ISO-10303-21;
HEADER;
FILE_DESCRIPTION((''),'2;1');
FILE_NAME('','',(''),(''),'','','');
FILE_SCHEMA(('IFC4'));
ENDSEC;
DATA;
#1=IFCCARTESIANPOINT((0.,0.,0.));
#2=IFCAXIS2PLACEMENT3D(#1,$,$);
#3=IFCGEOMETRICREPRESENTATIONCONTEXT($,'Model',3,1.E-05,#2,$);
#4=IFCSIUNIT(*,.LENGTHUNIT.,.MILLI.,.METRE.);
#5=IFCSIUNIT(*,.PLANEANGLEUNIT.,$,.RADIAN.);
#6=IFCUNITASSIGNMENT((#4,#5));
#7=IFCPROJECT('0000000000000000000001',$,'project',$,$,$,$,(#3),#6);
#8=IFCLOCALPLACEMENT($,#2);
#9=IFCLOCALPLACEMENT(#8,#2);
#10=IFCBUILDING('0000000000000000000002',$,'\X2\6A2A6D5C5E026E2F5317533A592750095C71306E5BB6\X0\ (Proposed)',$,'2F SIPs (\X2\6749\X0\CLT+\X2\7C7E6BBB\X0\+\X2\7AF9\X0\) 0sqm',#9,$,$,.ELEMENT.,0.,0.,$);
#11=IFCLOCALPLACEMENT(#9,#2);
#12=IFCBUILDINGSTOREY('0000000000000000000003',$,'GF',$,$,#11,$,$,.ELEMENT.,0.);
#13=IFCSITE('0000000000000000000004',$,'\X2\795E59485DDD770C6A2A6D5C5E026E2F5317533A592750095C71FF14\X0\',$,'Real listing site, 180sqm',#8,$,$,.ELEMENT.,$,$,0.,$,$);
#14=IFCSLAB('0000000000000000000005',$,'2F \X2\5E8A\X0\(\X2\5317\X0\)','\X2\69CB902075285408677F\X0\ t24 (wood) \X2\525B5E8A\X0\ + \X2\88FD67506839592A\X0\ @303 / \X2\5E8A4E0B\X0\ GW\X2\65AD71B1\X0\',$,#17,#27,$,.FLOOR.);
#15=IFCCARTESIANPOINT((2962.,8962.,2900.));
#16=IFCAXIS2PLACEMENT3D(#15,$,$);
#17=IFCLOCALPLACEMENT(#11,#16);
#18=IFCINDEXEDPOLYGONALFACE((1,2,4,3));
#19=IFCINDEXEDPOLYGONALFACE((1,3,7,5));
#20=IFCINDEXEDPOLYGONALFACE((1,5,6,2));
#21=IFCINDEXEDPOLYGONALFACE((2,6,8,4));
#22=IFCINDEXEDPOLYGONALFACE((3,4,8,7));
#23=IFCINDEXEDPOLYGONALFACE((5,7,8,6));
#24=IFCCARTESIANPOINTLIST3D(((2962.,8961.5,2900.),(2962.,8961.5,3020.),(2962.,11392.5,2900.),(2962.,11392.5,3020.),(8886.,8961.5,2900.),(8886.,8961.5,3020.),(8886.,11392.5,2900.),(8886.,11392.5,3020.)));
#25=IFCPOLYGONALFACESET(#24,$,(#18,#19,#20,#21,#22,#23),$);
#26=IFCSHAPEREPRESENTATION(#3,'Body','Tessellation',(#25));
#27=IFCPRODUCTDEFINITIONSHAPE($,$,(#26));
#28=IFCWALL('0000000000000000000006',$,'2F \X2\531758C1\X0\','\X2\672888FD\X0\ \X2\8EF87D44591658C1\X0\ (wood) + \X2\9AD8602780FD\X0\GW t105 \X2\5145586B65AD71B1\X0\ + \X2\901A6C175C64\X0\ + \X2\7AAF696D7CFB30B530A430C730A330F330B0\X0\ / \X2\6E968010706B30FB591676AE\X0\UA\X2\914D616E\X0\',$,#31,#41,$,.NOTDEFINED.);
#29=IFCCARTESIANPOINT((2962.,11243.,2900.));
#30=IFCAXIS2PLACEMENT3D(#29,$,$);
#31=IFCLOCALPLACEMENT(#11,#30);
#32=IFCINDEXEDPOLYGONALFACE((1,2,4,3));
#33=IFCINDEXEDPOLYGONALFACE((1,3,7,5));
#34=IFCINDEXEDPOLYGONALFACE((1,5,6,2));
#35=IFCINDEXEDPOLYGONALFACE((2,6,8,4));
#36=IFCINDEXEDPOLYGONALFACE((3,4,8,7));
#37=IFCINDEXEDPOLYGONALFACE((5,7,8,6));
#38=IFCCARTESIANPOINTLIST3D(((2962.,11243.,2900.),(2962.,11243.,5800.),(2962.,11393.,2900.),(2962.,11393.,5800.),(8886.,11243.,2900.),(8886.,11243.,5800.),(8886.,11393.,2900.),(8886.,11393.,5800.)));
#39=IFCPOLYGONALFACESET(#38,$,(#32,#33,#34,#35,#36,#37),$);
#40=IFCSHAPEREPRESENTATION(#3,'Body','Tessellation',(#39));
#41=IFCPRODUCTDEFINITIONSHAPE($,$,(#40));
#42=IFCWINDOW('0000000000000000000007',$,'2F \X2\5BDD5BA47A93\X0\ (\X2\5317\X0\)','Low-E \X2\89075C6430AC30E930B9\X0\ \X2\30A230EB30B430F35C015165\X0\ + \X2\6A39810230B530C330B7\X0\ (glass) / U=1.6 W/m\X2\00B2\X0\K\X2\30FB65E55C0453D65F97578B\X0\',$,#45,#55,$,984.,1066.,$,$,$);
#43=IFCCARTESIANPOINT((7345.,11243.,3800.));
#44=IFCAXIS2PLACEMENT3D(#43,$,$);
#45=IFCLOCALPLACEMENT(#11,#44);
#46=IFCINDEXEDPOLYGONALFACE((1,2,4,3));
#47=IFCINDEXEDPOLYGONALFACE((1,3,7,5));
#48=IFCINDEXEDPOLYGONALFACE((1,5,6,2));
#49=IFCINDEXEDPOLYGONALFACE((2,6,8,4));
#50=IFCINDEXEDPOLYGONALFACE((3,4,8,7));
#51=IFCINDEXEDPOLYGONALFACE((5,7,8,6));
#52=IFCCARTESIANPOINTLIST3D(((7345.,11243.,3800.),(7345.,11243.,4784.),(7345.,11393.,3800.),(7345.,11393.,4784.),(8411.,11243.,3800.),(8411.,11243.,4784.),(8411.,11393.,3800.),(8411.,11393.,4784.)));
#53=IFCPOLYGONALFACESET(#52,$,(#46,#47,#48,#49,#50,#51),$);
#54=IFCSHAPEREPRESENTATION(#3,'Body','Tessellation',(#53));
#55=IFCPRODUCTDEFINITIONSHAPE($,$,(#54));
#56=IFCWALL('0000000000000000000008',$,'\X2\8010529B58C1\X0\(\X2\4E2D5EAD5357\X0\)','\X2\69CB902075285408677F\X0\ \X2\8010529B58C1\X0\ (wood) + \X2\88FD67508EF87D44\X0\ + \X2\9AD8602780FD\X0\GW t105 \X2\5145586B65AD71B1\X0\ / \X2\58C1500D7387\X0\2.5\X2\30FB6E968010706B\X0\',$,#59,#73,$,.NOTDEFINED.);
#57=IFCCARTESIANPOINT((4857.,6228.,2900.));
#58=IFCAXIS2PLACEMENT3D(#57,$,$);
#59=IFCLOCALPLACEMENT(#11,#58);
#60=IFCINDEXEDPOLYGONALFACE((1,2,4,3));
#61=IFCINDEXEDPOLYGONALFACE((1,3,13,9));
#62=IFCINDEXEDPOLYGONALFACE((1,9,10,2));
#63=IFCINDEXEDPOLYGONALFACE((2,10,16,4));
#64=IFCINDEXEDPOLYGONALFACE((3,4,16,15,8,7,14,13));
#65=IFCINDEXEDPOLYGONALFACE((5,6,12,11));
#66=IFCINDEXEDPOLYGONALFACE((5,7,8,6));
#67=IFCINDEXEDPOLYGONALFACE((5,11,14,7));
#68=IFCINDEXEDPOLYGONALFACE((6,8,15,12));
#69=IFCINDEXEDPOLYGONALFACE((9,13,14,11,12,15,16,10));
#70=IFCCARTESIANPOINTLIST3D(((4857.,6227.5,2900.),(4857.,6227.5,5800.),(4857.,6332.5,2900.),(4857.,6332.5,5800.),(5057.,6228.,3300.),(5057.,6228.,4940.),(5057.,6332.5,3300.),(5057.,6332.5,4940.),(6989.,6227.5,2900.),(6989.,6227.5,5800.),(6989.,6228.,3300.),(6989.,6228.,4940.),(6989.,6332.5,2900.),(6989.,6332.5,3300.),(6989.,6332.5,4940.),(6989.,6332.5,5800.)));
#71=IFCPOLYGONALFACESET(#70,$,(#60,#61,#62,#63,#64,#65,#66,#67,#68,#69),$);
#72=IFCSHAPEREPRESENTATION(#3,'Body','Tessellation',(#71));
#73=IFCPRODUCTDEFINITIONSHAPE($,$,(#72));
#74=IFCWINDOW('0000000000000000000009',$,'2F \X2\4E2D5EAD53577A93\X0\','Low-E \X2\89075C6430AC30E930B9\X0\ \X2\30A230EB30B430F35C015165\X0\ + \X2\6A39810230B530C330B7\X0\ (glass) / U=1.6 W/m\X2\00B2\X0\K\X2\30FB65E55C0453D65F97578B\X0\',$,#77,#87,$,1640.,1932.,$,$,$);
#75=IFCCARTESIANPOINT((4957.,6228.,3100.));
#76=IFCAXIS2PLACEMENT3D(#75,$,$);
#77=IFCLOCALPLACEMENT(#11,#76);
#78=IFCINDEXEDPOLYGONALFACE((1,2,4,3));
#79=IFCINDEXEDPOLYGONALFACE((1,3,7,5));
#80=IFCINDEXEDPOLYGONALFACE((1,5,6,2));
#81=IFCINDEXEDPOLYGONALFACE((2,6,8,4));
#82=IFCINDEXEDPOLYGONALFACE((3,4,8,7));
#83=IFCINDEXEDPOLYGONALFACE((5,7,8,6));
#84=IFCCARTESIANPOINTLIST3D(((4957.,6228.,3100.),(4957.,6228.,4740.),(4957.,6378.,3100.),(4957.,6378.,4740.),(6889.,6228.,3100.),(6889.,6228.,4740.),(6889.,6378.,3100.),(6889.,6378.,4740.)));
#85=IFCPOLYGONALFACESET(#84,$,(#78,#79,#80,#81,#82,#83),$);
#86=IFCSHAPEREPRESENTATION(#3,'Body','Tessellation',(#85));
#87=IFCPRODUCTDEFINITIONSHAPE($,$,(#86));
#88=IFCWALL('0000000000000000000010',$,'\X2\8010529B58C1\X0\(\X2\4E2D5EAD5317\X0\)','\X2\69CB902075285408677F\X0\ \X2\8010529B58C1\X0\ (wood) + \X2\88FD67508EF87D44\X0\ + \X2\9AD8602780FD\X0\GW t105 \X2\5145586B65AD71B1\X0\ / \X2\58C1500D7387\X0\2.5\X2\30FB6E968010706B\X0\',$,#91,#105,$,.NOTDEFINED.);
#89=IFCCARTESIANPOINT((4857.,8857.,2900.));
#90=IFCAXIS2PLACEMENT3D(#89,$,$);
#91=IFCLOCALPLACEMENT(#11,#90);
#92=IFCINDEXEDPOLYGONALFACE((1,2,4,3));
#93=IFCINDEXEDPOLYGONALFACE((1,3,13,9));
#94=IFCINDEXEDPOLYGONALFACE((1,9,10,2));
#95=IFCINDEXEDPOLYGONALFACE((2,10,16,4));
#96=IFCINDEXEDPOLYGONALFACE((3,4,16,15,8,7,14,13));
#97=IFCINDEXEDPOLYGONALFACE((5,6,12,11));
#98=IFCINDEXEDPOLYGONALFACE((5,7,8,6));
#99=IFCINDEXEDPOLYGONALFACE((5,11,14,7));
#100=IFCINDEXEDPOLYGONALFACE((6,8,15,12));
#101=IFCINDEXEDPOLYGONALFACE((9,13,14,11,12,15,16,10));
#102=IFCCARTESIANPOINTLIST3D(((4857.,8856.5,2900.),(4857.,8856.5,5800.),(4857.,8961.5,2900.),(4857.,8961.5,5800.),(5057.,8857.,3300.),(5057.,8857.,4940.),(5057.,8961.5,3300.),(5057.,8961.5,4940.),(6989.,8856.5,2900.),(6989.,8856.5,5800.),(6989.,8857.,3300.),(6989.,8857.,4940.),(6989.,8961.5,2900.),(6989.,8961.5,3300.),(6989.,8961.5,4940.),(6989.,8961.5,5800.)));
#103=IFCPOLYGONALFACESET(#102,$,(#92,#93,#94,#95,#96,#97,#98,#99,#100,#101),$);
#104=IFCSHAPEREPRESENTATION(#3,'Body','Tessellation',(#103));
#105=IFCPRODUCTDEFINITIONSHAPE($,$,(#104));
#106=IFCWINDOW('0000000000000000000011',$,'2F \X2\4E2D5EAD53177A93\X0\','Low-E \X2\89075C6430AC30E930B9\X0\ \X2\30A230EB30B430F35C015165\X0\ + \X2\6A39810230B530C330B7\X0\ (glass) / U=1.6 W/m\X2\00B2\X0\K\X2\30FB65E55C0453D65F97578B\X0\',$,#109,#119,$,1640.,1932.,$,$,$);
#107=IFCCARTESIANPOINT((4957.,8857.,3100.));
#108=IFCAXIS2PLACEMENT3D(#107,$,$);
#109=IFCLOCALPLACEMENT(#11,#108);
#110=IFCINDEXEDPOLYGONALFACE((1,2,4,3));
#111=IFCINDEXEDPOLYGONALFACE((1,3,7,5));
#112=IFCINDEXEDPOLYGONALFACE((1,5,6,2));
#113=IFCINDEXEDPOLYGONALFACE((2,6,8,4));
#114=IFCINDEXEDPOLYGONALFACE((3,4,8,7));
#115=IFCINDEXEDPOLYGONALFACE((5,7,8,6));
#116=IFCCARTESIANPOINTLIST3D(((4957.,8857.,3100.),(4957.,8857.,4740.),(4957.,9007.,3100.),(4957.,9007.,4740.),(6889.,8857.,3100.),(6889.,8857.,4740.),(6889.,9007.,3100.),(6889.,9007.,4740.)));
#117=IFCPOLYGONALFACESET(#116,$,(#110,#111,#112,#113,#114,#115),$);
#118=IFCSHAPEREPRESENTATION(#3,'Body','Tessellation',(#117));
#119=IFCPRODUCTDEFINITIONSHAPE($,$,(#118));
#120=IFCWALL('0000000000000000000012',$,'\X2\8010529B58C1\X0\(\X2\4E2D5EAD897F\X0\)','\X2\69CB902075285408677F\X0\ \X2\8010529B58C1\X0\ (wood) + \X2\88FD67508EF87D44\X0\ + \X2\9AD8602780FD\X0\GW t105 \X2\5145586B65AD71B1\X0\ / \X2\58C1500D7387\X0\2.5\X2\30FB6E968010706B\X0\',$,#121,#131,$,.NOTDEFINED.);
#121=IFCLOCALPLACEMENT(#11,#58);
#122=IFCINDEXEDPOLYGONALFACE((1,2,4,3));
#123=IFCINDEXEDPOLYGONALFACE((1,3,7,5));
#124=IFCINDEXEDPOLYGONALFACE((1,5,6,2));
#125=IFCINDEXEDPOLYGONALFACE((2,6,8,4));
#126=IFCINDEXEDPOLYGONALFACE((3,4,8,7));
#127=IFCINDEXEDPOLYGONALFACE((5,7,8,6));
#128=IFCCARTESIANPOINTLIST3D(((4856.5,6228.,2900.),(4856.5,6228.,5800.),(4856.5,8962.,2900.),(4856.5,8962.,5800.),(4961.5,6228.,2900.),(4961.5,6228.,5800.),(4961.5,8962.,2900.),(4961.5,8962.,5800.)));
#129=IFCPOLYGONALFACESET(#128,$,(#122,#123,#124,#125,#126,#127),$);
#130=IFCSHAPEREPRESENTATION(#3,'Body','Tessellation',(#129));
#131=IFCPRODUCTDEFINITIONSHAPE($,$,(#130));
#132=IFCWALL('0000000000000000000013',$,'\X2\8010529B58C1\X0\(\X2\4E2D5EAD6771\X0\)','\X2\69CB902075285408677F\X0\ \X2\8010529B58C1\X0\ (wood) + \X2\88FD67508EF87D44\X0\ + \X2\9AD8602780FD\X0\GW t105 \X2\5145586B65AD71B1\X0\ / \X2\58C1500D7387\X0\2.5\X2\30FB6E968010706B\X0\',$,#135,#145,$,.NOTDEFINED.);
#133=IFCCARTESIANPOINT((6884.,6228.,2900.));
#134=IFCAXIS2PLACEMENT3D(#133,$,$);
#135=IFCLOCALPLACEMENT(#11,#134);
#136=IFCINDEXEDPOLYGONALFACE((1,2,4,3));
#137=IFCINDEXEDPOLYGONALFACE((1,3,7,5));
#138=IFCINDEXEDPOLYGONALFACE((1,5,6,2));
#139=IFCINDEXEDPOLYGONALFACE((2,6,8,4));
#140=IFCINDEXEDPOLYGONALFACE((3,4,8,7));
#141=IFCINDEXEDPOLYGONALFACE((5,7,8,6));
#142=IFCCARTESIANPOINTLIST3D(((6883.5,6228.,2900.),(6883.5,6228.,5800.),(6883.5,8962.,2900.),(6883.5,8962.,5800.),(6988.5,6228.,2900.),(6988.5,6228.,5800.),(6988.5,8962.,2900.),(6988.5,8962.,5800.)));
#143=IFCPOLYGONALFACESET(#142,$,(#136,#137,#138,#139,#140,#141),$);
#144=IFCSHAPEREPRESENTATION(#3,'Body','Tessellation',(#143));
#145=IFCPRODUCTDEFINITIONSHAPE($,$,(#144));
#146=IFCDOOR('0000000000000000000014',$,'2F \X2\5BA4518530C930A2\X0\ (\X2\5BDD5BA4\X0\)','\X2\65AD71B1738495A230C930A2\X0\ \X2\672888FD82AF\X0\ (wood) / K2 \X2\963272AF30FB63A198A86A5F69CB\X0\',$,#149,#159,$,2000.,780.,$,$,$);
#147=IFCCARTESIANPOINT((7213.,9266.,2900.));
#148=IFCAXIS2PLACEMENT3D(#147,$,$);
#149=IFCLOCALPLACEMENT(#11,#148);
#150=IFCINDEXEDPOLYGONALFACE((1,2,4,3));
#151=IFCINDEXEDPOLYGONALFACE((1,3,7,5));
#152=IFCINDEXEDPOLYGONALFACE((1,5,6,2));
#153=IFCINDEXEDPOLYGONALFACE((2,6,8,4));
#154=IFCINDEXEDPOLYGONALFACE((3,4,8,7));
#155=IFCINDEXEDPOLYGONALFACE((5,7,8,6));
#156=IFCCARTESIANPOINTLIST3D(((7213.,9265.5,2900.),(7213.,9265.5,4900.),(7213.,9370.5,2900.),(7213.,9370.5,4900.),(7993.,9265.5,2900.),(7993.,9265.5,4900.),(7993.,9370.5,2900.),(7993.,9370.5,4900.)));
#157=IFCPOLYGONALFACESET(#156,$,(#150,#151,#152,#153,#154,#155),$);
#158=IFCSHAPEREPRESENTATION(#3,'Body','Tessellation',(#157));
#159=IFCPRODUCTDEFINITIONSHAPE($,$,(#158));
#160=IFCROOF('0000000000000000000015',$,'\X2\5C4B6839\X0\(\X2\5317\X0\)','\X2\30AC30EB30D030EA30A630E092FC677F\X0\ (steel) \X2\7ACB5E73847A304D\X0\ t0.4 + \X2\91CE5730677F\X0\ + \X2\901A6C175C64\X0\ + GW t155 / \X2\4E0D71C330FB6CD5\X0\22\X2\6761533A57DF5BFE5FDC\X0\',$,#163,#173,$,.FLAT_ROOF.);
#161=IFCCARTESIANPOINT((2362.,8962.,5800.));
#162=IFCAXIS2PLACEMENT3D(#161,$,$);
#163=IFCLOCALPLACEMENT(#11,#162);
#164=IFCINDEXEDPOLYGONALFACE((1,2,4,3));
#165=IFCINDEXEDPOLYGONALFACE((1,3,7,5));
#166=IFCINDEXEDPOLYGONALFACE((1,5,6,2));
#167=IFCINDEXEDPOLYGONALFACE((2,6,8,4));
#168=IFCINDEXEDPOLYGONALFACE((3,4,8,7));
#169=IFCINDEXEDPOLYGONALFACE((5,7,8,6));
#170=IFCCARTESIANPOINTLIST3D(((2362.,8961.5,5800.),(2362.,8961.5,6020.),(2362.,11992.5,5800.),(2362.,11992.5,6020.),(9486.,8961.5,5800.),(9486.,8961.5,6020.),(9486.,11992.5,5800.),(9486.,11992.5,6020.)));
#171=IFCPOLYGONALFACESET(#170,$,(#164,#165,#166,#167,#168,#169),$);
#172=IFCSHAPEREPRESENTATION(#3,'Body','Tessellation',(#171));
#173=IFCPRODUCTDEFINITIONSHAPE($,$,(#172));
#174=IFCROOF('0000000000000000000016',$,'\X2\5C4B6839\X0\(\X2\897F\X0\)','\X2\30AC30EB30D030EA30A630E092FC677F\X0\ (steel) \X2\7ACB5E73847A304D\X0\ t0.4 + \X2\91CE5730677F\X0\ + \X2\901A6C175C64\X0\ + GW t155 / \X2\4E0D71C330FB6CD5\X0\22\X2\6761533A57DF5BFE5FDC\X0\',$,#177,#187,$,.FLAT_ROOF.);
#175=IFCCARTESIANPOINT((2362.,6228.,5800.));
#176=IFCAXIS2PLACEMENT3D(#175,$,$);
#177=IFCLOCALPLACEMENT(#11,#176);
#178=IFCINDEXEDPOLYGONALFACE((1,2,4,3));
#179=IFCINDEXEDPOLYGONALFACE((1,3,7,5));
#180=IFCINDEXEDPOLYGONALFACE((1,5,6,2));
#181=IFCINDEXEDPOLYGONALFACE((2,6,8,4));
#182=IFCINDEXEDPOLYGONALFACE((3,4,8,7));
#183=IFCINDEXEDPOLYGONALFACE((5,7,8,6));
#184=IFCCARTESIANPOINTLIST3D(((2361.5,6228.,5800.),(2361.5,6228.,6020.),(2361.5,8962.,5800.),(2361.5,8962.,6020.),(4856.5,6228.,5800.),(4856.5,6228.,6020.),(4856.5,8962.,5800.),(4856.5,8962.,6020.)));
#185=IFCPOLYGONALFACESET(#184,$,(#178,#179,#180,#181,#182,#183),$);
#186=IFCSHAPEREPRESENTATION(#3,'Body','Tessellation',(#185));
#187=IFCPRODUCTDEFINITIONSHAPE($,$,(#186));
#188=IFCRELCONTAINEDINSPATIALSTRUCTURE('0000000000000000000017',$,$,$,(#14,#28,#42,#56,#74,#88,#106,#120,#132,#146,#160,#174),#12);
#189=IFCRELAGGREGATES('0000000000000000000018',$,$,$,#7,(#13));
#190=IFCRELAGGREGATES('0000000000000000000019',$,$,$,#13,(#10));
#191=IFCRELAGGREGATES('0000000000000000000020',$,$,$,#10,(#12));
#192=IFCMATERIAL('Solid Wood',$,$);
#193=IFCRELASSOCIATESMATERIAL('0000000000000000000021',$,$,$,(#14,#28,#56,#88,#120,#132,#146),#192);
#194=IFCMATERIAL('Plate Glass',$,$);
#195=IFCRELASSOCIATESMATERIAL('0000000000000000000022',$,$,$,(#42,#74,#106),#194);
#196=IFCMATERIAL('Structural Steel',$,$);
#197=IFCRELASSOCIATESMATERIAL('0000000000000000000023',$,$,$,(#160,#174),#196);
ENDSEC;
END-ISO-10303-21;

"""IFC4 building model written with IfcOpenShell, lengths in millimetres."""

from ifc_helpers import new_model, si_unit, frame, frame_2d, origin, place, context, project, spatial, rectangle, extrude, material, element, fill, save


model = new_model("IFC4")

# Units and contexts
model_context = context("Model", 3, precision=1e-05, world=origin())
ifc_project = project(units=[si_unit("LENGTHUNIT", "METRE", prefix="MILLI"), si_unit("PLANEANGLEUNIT", "RADIAN")], contexts=[model_context])

# Site, building, storey
site_placement = place(None, origin())
site = spatial("IfcSite", under=ifc_project, at=site_placement, Name="神奈川県横浜市港北区大倉山４", ObjectType="Real listing site, 180sqm", CompositionType="ELEMENT", RefElevation=0.0)
building_placement = place(site_placement, origin())
building = spatial("IfcBuilding", under=site, at=building_placement, Name="横浜市港北区大倉山の家 (Proposed)", ObjectType="2F SIPs (杉CLT+籾殻+竹) 0sqm", CompositionType="ELEMENT", ElevationOfRefHeight=0.0, ElevationOfTerrain=0.0)
storey_placement = place(building_placement, origin())
storey = spatial("IfcBuildingStorey", under=building, at=storey_placement, Name="GF", CompositionType="ELEMENT", Elevation=0.0)

# Slab
ifc_material_1 = material(Name="Solid Wood")
slab_placement = place(storey_placement, frame((2962.0, 8962.0, 2900.0)))
element("IfcSlab", 1, at=slab_placement, inside=storey, material=ifc_material_1, Name="2F 床(北)", Description="構造用合板 t24 (wood) 剛床 + 製材根太 @303 / 床下 GW断熱", PredefinedType="FLOOR", context=model_context, shape_type="SweptSolid", body=[
    extrude(rectangle(XDim=5924.0, YDim=2431.0, at=frame_2d((2962.0, 1215.0))), frame((2962.0, 8962.0, 2900.0)), (0.0, 0.0, 1.0), 120.0),
])

# Walls, openings, windows
wall_1_placement = place(storey_placement, frame((2962.0, 11243.0, 2900.0)))
wall_1 = element("IfcWall", 2, at=wall_1_placement, inside=storey, material=ifc_material_1, Name="2F 北壁", Description="木製 軸組外壁 (wood) + 高性能GW t105 充填断熱 + 通気層 + 窯業系サイディング / 準耐火・外皮UA配慮", PredefinedType="NOTDEFINED", context=model_context, shape_type="SweptSolid", body=[
    extrude(rectangle(XDim=5924.0, YDim=150.0, at=frame_2d((2962.0, 75.0))), frame((2962.0, 11243.0, 2900.0)), (0.0, 0.0, 1.0), 2900.0),
])
opening_1_placement = place(storey_placement, frame((7345.0, 11243.0, 3800.0)))
opening_1 = element("IfcOpeningElement", 3, at=opening_1_placement, cuts=wall_1, PredefinedType="NOTDEFINED", context=model_context, shape_type="SweptSolid", body=[
    extrude(rectangle(XDim=1066.0, YDim=150.0, at=frame_2d((533.0, 75.0))), frame((7345.0, 11243.0, 3800.0)), (0.0, 0.0, 1.0), 984.0),
])
ifc_material_2 = material(Name="Plate Glass")
window_1_placement = place(storey_placement, frame((7345.0, 11243.0, 3800.0)))
window_1 = element("IfcWindow", 4, at=window_1_placement, inside=storey, material=ifc_material_2, Name="2F 寝室窓 (北)", Description="Low-E 複層ガラス アルゴン封入 + 樹脂サッシ (glass) / U=1.6 W/m²K・日射取得型", OverallHeight=984.0, OverallWidth=1066.0, context=model_context, shape_type="SweptSolid", body=[
    extrude(rectangle(XDim=1066.0, YDim=150.0, at=frame_2d((533.0, 75.0))), frame((7345.0, 11243.0, 3800.0)), (0.0, 0.0, 1.0), 984.0),
])
fill(opening_1, window_1)
wall_2_placement = place(storey_placement, frame((4857.0, 6228.0, 2900.0)))
wall_2 = element("IfcWall", 5, at=wall_2_placement, inside=storey, material=ifc_material_1, Name="耐力壁(中庭南)", Description="構造用合板 耐力壁 (wood) + 製材軸組 + 高性能GW t105 充填断熱 / 壁倍率2.5・準耐火", PredefinedType="NOTDEFINED", context=model_context, shape_type="SweptSolid", body=[
    extrude(rectangle(XDim=2132.0, YDim=105.0, at=frame_2d((1066.0, 52.0))), frame((4857.0, 6228.0, 2900.0)), (0.0, 0.0, 1.0), 2900.0),
])
opening_2_placement = place(storey_placement, frame((4957.0, 6228.0, 3100.0)))
opening_2 = element("IfcOpeningElement", 6, at=opening_2_placement, cuts=wall_2, PredefinedType="NOTDEFINED", context=model_context, shape_type="SweptSolid", body=[
    extrude(rectangle(XDim=1932.0, YDim=150.0, at=frame_2d((966.0, 75.0))), frame((4957.0, 6228.0, 3100.0)), (0.0, 0.0, 1.0), 1640.0),
])
window_2_placement = place(storey_placement, frame((4957.0, 6228.0, 3100.0)))
window_2 = element("IfcWindow", 7, at=window_2_placement, inside=storey, material=ifc_material_2, Name="2F 中庭南窓", Description="Low-E 複層ガラス アルゴン封入 + 樹脂サッシ (glass) / U=1.6 W/m²K・日射取得型", OverallHeight=1640.0, OverallWidth=1932.0, context=model_context, shape_type="SweptSolid", body=[
    extrude(rectangle(XDim=1932.0, YDim=150.0, at=frame_2d((966.0, 75.0))), frame((4957.0, 6228.0, 3100.0)), (0.0, 0.0, 1.0), 1640.0),
])
fill(opening_2, window_2)
wall_3_placement = place(storey_placement, frame((4857.0, 8857.0, 2900.0)))
wall_3 = element("IfcWall", 8, at=wall_3_placement, inside=storey, material=ifc_material_1, Name="耐力壁(中庭北)", Description="構造用合板 耐力壁 (wood) + 製材軸組 + 高性能GW t105 充填断熱 / 壁倍率2.5・準耐火", PredefinedType="NOTDEFINED", context=model_context, shape_type="SweptSolid", body=[
    extrude(rectangle(XDim=2132.0, YDim=105.0, at=frame_2d((1066.0, 52.0))), frame((4857.0, 8857.0, 2900.0)), (0.0, 0.0, 1.0), 2900.0),
])
opening_3_placement = place(storey_placement, frame((4957.0, 8857.0, 3100.0)))
opening_3 = element("IfcOpeningElement", 9, at=opening_3_placement, cuts=wall_3, PredefinedType="NOTDEFINED", context=model_context, shape_type="SweptSolid", body=[
    extrude(rectangle(XDim=1932.0, YDim=150.0, at=frame_2d((966.0, 75.0))), frame((4957.0, 8857.0, 3100.0)), (0.0, 0.0, 1.0), 1640.0),
])
window_3_placement = place(storey_placement, frame((4957.0, 8857.0, 3100.0)))
window_3 = element("IfcWindow", 10, at=window_3_placement, inside=storey, material=ifc_material_2, Name="2F 中庭北窓", Description="Low-E 複層ガラス アルゴン封入 + 樹脂サッシ (glass) / U=1.6 W/m²K・日射取得型", OverallHeight=1640.0, OverallWidth=1932.0, context=model_context, shape_type="SweptSolid", body=[
    extrude(rectangle(XDim=1932.0, YDim=150.0, at=frame_2d((966.0, 75.0))), frame((4957.0, 8857.0, 3100.0)), (0.0, 0.0, 1.0), 1640.0),
])
fill(opening_3, window_3)

# Walls
wall_4_placement = place(storey_placement, frame((4857.0, 6228.0, 2900.0)))
element("IfcWall", 11, at=wall_4_placement, inside=storey, material=ifc_material_1, Name="耐力壁(中庭西)", Description="構造用合板 耐力壁 (wood) + 製材軸組 + 高性能GW t105 充填断熱 / 壁倍率2.5・準耐火", PredefinedType="NOTDEFINED", context=model_context, shape_type="SweptSolid", body=[
    extrude(rectangle(XDim=105.0, YDim=2734.0, at=frame_2d((52.0, 1367.0))), frame((4857.0, 6228.0, 2900.0)), (0.0, 0.0, 1.0), 2900.0),
])
wall_5_placement = place(storey_placement, frame((6884.0, 6228.0, 2900.0)))
element("IfcWall", 12, at=wall_5_placement, inside=storey, material=ifc_material_1, Name="耐力壁(中庭東)", Description="構造用合板 耐力壁 (wood) + 製材軸組 + 高性能GW t105 充填断熱 / 壁倍率2.5・準耐火", PredefinedType="NOTDEFINED", context=model_context, shape_type="SweptSolid", body=[
    extrude(rectangle(XDim=105.0, YDim=2734.0, at=frame_2d((52.0, 1367.0))), frame((6884.0, 6228.0, 2900.0)), (0.0, 0.0, 1.0), 2900.0),
])

# Door
door_placement = place(storey_placement, frame((7213.0, 9266.0, 2900.0)))
element("IfcDoor", 13, at=door_placement, inside=storey, material=ifc_material_1, Name="2F 室内ドア (寝室)", Description="断熱玄関ドア 木製芯 (wood) / K2 防犯・採風機構", OverallHeight=2000.0, OverallWidth=780.0, context=model_context, shape_type="SweptSolid", body=[
    extrude(rectangle(XDim=780.0, YDim=105.0, at=frame_2d((390.0, 52.0))), frame((7213.0, 9266.0, 2900.0)), (0.0, 0.0, 1.0), 2000.0),
])

# Roofs
ifc_material_3 = material(Name="Structural Steel")
for number, where, name in (
    (14, (2362.0, 8962.0, 5800.0), "屋根(北)"),
):
    element("IfcRoof", number, at=place(storey_placement, frame(where)), inside=storey, material=ifc_material_3, Name=name, Description="ガルバリウム鋼板 (steel) 立平葺き t0.4 + 野地板 + 通気層 + GW t155 / 不燃・法22条区域対応", PredefinedType="FLAT_ROOF", context=model_context, shape_type="SweptSolid", body=[
        extrude(rectangle(XDim=7124.0, YDim=3031.0, at=frame_2d((3562.0, 1515.0))), frame((2362.0, 8962.0, 5800.0)), (0.0, 0.0, 1.0), 220.0),
    ])
roof_1_placement = place(storey_placement, frame((2362.0, 6228.0, 5800.0)))
element("IfcRoof", 15, at=roof_1_placement, inside=storey, material=ifc_material_3, Name="屋根(西)", Description="ガルバリウム鋼板 (steel) 立平葺き t0.4 + 野地板 + 通気層 + GW t155 / 不燃・法22条区域対応", PredefinedType="FLAT_ROOF", context=model_context, shape_type="SweptSolid", body=[
    extrude(rectangle(XDim=2495.0, YDim=2734.0, at=frame_2d((1247.0, 1367.0))), frame((2362.0, 6228.0, 5800.0)), (0.0, 0.0, 1.0), 220.0),
])

save(model, "model.ifc")
